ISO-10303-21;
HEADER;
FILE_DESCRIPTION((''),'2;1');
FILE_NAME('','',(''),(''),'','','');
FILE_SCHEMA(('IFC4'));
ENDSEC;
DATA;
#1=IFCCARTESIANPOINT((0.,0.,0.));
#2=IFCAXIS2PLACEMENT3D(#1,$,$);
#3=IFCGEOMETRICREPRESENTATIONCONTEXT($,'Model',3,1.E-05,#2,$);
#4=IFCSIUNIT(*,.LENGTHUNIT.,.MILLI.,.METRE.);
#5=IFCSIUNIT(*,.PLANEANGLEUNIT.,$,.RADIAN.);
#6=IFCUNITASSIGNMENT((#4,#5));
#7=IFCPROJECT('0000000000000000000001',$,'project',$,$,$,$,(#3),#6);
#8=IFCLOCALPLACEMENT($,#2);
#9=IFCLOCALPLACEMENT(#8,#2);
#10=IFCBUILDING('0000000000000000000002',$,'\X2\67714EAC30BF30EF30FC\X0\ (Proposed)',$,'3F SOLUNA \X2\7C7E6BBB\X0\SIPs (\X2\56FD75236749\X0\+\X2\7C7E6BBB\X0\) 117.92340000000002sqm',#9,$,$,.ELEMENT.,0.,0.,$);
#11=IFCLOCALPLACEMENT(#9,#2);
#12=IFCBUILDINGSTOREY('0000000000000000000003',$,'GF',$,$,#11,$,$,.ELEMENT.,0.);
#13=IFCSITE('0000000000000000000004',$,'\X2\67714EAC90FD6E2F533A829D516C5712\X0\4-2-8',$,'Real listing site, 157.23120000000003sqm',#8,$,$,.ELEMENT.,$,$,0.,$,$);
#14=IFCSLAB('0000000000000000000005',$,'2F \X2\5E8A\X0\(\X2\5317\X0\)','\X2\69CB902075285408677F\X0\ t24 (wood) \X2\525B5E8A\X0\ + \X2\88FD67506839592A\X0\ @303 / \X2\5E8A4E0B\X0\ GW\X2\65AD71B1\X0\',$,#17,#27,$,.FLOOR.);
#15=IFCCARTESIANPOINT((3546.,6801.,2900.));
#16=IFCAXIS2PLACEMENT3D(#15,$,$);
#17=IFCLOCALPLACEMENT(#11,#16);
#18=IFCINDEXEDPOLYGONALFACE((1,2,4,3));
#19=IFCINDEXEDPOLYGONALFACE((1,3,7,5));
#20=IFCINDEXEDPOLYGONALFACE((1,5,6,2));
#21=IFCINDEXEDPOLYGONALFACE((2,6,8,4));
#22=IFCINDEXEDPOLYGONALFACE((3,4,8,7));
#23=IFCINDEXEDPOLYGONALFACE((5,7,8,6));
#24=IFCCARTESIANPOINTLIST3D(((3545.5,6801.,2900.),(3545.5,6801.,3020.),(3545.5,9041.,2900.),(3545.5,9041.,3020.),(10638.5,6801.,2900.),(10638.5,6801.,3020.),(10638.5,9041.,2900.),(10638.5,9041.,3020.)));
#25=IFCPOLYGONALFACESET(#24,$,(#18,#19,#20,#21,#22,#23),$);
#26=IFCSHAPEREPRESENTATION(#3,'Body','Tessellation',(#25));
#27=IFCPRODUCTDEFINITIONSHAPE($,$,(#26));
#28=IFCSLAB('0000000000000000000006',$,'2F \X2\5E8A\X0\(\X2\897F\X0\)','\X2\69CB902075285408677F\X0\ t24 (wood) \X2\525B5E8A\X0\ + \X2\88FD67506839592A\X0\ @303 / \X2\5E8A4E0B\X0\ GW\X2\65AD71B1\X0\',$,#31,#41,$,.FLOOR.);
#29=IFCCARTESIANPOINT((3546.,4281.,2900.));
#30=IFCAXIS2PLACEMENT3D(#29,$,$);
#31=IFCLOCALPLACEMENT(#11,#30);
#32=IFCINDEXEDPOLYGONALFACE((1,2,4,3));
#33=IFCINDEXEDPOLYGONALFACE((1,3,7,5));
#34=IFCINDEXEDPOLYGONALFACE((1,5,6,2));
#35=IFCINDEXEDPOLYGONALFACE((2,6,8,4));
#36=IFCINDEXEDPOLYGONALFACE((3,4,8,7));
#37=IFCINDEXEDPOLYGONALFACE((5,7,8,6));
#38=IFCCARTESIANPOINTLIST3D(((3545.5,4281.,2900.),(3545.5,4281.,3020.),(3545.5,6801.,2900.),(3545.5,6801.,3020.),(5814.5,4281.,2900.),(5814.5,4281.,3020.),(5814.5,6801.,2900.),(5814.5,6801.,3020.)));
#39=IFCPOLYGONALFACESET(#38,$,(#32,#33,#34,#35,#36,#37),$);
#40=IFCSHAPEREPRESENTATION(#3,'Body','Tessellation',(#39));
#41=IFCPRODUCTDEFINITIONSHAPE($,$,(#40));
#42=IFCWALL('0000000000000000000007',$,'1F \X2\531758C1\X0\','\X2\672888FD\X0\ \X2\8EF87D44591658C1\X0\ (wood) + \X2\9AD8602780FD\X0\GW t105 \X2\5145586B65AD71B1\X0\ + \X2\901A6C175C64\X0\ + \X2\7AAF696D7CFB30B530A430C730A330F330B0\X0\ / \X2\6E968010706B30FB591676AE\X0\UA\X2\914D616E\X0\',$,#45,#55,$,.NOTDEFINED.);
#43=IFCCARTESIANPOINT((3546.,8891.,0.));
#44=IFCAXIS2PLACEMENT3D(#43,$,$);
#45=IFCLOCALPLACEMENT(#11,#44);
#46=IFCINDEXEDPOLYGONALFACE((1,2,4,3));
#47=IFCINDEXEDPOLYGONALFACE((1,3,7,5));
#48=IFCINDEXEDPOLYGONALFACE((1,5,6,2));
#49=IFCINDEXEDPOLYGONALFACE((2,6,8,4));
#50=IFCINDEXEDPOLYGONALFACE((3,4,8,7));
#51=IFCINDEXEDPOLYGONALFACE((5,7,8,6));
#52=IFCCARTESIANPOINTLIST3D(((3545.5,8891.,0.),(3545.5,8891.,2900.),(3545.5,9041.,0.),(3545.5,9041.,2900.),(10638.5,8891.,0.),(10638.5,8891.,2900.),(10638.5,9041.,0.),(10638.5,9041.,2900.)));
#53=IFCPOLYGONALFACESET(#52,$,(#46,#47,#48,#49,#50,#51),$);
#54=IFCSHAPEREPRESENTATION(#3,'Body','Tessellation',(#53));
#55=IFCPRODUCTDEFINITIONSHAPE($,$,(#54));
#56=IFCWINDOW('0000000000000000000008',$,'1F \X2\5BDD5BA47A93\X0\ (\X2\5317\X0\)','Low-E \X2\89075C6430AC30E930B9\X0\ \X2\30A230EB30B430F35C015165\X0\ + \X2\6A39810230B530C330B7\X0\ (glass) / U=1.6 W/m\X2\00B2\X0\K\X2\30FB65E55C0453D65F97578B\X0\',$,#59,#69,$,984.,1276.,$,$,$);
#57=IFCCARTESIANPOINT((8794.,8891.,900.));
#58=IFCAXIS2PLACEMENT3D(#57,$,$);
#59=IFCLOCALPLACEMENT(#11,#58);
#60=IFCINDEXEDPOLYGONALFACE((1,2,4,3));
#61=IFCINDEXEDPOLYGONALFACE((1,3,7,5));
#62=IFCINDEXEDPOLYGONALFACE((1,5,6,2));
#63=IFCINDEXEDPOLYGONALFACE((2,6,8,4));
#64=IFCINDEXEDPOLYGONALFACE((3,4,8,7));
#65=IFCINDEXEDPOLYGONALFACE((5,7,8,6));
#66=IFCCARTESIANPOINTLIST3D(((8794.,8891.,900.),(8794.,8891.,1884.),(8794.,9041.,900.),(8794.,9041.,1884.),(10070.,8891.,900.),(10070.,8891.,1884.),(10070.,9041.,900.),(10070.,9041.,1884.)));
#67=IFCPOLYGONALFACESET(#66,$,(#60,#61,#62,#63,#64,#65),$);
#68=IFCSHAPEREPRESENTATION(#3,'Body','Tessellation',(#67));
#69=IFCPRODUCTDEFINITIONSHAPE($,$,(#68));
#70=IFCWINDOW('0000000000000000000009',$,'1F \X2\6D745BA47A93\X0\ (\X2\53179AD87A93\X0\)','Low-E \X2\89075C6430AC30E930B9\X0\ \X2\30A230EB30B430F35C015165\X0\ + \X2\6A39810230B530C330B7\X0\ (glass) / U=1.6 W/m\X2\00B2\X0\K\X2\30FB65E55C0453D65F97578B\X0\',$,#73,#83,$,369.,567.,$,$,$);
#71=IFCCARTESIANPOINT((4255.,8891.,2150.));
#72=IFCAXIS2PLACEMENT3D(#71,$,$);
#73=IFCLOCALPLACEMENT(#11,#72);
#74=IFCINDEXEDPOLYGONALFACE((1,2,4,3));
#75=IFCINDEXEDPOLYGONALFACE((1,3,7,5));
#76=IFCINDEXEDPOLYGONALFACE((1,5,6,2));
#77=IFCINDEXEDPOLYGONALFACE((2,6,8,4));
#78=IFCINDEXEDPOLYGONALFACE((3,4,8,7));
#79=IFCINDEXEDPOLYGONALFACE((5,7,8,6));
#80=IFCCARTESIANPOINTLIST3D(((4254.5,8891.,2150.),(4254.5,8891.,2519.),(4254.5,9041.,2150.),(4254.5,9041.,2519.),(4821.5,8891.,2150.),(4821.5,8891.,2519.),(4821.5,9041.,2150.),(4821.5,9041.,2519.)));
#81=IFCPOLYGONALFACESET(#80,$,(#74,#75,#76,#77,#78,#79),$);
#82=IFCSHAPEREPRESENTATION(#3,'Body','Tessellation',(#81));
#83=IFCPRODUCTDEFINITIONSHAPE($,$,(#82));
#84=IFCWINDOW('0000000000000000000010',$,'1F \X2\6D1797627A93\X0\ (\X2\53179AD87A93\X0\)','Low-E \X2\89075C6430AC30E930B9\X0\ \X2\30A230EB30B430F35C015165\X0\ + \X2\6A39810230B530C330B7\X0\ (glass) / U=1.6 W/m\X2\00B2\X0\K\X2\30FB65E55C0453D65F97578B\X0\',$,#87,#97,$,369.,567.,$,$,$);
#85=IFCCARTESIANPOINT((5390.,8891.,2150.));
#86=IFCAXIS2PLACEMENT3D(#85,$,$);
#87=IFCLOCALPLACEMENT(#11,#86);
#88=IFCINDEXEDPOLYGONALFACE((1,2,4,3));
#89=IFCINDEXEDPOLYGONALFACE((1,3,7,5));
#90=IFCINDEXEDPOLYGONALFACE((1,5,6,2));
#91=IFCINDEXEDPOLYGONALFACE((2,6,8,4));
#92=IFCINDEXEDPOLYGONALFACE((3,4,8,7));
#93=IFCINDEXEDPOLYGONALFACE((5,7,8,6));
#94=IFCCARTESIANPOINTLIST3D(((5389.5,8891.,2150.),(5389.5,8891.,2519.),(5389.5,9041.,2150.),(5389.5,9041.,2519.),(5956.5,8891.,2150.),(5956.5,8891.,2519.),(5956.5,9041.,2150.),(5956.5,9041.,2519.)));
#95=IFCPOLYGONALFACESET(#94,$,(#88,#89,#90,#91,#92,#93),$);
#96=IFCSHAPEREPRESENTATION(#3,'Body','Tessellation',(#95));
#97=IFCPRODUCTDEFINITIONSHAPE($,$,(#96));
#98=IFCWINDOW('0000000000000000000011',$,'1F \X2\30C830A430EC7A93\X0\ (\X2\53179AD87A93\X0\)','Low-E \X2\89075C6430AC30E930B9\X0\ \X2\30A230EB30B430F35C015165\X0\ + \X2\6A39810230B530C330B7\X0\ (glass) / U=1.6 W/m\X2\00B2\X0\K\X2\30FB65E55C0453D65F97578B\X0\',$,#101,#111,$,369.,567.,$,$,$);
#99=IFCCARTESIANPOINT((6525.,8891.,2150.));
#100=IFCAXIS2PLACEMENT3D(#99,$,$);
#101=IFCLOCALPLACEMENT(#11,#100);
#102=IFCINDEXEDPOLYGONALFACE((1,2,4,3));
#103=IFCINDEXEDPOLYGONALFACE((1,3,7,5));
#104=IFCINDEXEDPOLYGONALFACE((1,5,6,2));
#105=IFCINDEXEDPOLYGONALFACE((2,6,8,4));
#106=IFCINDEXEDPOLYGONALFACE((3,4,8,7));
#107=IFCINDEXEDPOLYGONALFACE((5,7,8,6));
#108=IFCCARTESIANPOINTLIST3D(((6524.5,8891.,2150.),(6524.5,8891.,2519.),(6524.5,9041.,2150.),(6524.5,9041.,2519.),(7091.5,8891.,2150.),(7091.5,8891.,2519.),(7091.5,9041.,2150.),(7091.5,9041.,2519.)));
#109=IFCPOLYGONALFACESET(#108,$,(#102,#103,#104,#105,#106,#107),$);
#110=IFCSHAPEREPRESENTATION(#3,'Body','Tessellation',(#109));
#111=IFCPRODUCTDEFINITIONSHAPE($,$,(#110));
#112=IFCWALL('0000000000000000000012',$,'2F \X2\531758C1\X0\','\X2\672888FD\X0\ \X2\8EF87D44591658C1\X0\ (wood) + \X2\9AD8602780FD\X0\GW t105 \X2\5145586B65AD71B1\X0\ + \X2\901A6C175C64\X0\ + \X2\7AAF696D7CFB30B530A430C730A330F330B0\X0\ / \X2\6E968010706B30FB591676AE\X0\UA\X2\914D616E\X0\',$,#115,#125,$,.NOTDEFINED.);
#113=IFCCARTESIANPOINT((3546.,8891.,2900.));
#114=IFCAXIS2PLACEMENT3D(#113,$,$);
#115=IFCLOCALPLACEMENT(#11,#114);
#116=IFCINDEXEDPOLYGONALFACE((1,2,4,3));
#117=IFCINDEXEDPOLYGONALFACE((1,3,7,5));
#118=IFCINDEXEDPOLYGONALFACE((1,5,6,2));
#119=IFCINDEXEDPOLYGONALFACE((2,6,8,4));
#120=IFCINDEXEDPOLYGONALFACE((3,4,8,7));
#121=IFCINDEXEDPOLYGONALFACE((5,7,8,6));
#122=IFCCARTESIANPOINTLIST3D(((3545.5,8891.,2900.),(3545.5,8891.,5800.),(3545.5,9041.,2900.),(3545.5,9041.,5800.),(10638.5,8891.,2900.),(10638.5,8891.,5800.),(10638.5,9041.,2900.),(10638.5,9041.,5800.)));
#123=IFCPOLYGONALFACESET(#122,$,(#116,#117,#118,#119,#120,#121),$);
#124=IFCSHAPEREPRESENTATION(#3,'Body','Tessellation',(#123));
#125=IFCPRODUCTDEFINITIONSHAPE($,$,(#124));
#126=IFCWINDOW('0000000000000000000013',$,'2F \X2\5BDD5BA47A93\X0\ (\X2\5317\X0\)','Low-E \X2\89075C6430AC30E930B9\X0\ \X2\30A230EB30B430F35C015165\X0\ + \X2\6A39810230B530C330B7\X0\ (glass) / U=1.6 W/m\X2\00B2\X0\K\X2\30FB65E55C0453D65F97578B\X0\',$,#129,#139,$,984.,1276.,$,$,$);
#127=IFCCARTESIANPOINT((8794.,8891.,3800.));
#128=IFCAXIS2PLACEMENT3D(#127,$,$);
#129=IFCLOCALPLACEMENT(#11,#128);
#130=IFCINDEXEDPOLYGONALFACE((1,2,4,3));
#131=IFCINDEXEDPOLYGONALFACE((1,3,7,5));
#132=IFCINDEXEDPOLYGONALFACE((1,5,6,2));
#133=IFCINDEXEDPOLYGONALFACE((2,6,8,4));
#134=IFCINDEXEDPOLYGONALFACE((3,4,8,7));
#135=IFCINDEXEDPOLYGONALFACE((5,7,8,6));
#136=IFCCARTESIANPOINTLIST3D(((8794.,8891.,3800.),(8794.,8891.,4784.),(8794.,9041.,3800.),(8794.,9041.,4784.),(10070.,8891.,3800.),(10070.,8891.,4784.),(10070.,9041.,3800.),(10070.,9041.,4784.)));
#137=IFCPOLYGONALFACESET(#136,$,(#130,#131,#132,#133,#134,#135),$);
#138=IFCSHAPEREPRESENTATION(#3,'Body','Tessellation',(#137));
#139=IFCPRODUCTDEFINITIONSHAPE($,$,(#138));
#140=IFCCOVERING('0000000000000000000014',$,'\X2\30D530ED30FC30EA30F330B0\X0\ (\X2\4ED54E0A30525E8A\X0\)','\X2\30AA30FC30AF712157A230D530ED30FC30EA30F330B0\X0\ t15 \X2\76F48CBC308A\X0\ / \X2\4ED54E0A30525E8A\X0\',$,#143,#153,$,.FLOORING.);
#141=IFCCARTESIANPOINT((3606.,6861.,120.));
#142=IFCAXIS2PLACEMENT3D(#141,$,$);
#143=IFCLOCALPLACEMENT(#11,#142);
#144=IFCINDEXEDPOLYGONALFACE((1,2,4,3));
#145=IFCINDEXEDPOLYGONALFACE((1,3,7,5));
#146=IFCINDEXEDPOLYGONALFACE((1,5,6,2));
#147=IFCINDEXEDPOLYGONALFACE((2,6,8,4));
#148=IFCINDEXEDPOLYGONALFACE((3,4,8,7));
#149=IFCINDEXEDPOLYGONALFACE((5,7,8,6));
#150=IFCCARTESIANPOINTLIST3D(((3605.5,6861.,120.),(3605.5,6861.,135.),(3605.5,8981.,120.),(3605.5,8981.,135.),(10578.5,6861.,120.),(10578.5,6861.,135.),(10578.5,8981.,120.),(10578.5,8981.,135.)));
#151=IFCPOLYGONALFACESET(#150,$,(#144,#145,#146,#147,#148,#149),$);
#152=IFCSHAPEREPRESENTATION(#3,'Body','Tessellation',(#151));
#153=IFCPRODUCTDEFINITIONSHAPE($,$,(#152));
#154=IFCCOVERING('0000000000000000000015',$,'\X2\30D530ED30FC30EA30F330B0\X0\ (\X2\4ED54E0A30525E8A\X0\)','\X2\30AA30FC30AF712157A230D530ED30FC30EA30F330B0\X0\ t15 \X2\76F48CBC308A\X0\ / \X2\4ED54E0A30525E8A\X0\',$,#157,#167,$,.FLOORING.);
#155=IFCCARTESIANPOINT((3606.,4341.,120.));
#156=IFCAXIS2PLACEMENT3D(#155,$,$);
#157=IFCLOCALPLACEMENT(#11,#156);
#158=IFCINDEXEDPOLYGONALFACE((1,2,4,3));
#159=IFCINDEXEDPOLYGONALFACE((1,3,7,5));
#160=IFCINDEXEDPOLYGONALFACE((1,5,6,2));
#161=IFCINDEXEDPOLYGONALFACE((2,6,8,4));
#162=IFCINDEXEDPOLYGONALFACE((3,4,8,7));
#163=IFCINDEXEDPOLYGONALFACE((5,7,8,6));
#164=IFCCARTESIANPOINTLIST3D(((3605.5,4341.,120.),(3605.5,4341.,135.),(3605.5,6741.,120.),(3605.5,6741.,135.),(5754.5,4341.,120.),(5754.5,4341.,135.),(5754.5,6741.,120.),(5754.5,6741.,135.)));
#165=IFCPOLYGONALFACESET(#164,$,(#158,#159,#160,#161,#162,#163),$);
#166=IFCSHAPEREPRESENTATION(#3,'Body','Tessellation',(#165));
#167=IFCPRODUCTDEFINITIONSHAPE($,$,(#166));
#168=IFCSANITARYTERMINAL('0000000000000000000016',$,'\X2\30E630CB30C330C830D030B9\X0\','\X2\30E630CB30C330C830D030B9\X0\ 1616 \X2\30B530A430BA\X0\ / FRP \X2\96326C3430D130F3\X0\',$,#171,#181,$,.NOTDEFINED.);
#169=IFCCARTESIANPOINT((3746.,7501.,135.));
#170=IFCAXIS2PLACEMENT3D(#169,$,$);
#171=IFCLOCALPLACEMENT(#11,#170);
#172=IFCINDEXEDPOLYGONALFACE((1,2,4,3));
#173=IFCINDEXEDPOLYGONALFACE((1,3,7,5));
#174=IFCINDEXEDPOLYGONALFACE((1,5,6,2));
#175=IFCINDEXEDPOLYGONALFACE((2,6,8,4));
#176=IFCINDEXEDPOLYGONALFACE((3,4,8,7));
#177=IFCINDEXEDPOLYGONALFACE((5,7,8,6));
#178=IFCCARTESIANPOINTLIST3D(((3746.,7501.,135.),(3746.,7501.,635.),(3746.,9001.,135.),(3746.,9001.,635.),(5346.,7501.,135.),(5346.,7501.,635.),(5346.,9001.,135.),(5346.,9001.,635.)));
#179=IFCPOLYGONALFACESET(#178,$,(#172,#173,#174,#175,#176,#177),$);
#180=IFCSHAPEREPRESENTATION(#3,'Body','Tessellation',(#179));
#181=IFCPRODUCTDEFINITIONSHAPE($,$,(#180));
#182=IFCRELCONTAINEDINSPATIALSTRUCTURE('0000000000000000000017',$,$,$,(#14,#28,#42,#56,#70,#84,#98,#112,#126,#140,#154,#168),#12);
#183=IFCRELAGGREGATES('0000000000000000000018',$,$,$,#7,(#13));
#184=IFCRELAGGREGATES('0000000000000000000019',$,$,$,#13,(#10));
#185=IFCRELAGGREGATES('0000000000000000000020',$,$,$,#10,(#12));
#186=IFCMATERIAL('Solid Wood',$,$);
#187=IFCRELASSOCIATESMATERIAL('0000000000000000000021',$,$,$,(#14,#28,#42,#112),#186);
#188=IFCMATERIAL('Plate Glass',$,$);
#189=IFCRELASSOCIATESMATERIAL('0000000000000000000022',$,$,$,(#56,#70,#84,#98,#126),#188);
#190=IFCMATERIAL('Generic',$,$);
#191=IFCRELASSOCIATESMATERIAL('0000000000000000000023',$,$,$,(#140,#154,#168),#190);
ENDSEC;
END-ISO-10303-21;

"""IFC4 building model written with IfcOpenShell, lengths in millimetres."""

from ifc_helpers import new_model, si_unit, frame, frame_2d, origin, place, context, project, spatial, rectangle, extrude, material, element, fill, save


model = new_model("IFC4")

# Units and contexts
model_context = context("Model", 3, precision=1e-05, world=origin())
ifc_project = project(units=[si_unit("LENGTHUNIT", "METRE", prefix="MILLI"), si_unit("PLANEANGLEUNIT", "RADIAN")], contexts=[model_context])

# Site, building, storey
site_placement = place(None, origin())
site = spatial("IfcSite", under=ifc_project, at=site_placement, Name="東京都港区芝公園4-2-8", ObjectType="Real listing site, 157.23120000000003sqm", CompositionType="ELEMENT", RefElevation=0.0)
building_placement = place(site_placement, origin())
building = spatial("IfcBuilding", under=site, at=building_placement, Name="東京タワー (Proposed)", ObjectType="3F SOLUNA 籾殻SIPs (国産杉+籾殻) 117.92340000000002sqm", CompositionType="ELEMENT", ElevationOfRefHeight=0.0, ElevationOfTerrain=0.0)
storey_placement = place(building_placement, origin())
storey = spatial("IfcBuildingStorey", under=building, at=storey_placement, Name="GF", CompositionType="ELEMENT", Elevation=0.0)

# Slabs
ifc_material_1 = material(Name="Solid Wood")
slab_1_placement = place(storey_placement, frame((3546.0, 6801.0, 2900.0)))
element("IfcSlab", 1, at=slab_1_placement, inside=storey, material=ifc_material_1, Name="2F 床(北)", Description="構造用合板 t24 (wood) 剛床 + 製材根太 @303 / 床下 GW断熱", PredefinedType="FLOOR", context=model_context, shape_type="SweptSolid", body=[
    extrude(rectangle(XDim=7093.0, YDim=2240.0, at=frame_2d((3546.0, 1120.0))), frame((3546.0, 6801.0, 2900.0)), (0.0, 0.0, 1.0), 120.0),
])
slab_2_placement = place(storey_placement, frame((3546.0, 4281.0, 2900.0)))
element("IfcSlab", 2, at=slab_2_placement, inside=storey, material=ifc_material_1, Name="2F 床(西)", Description="構造用合板 t24 (wood) 剛床 + 製材根太 @303 / 床下 GW断熱", PredefinedType="FLOOR", context=model_context, shape_type="SweptSolid", body=[
    extrude(rectangle(XDim=2269.0, YDim=2520.0, at=frame_2d((1134.0, 1260.0))), frame((3546.0, 4281.0, 2900.0)), (0.0, 0.0, 1.0), 120.0),
])

# Wall, openings, windows
wall_1_placement = place(storey_placement, frame((3546.0, 8891.0, 0.0)))
wall_1 = element("IfcWall", 3, at=wall_1_placement, inside=storey, material=ifc_material_1, Name="1F 北壁", Description="木製 軸組外壁 (wood) + 高性能GW t105 充填断熱 + 通気層 + 窯業系サイディング / 準耐火・外皮UA配慮", PredefinedType="NOTDEFINED", context=model_context, shape_type="SweptSolid", body=[
    extrude(rectangle(XDim=7093.0, YDim=150.0, at=frame_2d((3546.0, 75.0))), frame((3546.0, 8891.0, 0.0)), (0.0, 0.0, 1.0), 2900.0),
])
opening_1_placement = place(storey_placement, frame((8794.0, 8891.0, 900.0)))
opening_1 = element("IfcOpeningElement", 4, at=opening_1_placement, cuts=wall_1, PredefinedType="NOTDEFINED", context=model_context, shape_type="SweptSolid", body=[
    extrude(rectangle(XDim=1276.0, YDim=150.0, at=frame_2d((638.0, 75.0))), frame((8794.0, 8891.0, 900.0)), (0.0, 0.0, 1.0), 984.0),
])
opening_2_placement = place(storey_placement, frame((4255.0, 8891.0, 2150.0)))
opening_2 = element("IfcOpeningElement", 5, at=opening_2_placement, cuts=wall_1, PredefinedType="NOTDEFINED", context=model_context, shape_type="SweptSolid", body=[
    extrude(rectangle(XDim=567.0, YDim=150.0, at=frame_2d((283.0, 75.0))), frame((4255.0, 8891.0, 2150.0)), (0.0, 0.0, 1.0), 369.0),
])
opening_3_placement = place(storey_placement, frame((5390.0, 8891.0, 2150.0)))
opening_3 = element("IfcOpeningElement", 6, at=opening_3_placement, cuts=wall_1, PredefinedType="NOTDEFINED", context=model_context, shape_type="SweptSolid", body=[
    extrude(rectangle(XDim=567.0, YDim=150.0, at=frame_2d((283.0, 75.0))), frame((5390.0, 8891.0, 2150.0)), (0.0, 0.0, 1.0), 369.0),
])
opening_4_placement = place(storey_placement, frame((6525.0, 8891.0, 2150.0)))
opening_4 = element("IfcOpeningElement", 7, at=opening_4_placement, cuts=wall_1, PredefinedType="NOTDEFINED", context=model_context, shape_type="SweptSolid", body=[
    extrude(rectangle(XDim=567.0, YDim=150.0, at=frame_2d((283.0, 75.0))), frame((6525.0, 8891.0, 2150.0)), (0.0, 0.0, 1.0), 369.0),
])
ifc_material_2 = material(Name="Plate Glass")
window_1_placement = place(storey_placement, frame((8794.0, 8891.0, 900.0)))
window_1 = element("IfcWindow", 8, at=window_1_placement, inside=storey, material=ifc_material_2, Name="1F 寝室窓 (北)", Description="Low-E 複層ガラス アルゴン封入 + 樹脂サッシ (glass) / U=1.6 W/m²K・日射取得型", OverallHeight=984.0, OverallWidth=1276.0, context=model_context, shape_type="SweptSolid", body=[
    extrude(rectangle(XDim=1276.0, YDim=150.0, at=frame_2d((638.0, 75.0))), frame((8794.0, 8891.0, 900.0)), (0.0, 0.0, 1.0), 984.0),
])
fill(opening_1, window_1)
window_2_placement = place(storey_placement, frame((4255.0, 8891.0, 2150.0)))
window_2 = element("IfcWindow", 9, at=window_2_placement, inside=storey, material=ifc_material_2, Name="1F 浴室窓 (北高窓)", Description="Low-E 複層ガラス アルゴン封入 + 樹脂サッシ (glass) / U=1.6 W/m²K・日射取得型", OverallHeight=369.0, OverallWidth=567.0, context=model_context, shape_type="SweptSolid", body=[
    extrude(rectangle(XDim=567.0, YDim=150.0, at=frame_2d((283.0, 75.0))), frame((4255.0, 8891.0, 2150.0)), (0.0, 0.0, 1.0), 369.0),
])
fill(opening_2, window_2)
window_3_placement = place(storey_placement, frame((5390.0, 8891.0, 2150.0)))
window_3 = element("IfcWindow", 10, at=window_3_placement, inside=storey, material=ifc_material_2, Name="1F 洗面窓 (北高窓)", Description="Low-E 複層ガラス アルゴン封入 + 樹脂サッシ (glass) / U=1.6 W/m²K・日射取得型", OverallHeight=369.0, OverallWidth=567.0, context=model_context, shape_type="SweptSolid", body=[
    extrude(rectangle(XDim=567.0, YDim=150.0, at=frame_2d((283.0, 75.0))), frame((5390.0, 8891.0, 2150.0)), (0.0, 0.0, 1.0), 369.0),
])
fill(opening_3, window_3)
window_4_placement = place(storey_placement, frame((6525.0, 8891.0, 2150.0)))
window_4 = element("IfcWindow", 11, at=window_4_placement, inside=storey, material=ifc_material_2, Name="1F トイレ窓 (北高窓)", Description="Low-E 複層ガラス アルゴン封入 + 樹脂サッシ (glass) / U=1.6 W/m²K・日射取得型", OverallHeight=369.0, OverallWidth=567.0, context=model_context, shape_type="SweptSolid", body=[
    extrude(rectangle(XDim=567.0, YDim=150.0, at=frame_2d((283.0, 75.0))), frame((6525.0, 8891.0, 2150.0)), (0.0, 0.0, 1.0), 369.0),
])
fill(opening_4, window_4)

# Wall, opening, window
wall_2_placement = place(storey_placement, frame((3546.0, 8891.0, 2900.0)))
wall_2 = element("IfcWall", 12, at=wall_2_placement, inside=storey, material=ifc_material_1, Name="2F 北壁", Description="木製 軸組外壁 (wood) + 高性能GW t105 充填断熱 + 通気層 + 窯業系サイディング / 準耐火・外皮UA配慮", PredefinedType="NOTDEFINED", context=model_context, shape_type="SweptSolid", body=[
    extrude(rectangle(XDim=7093.0, YDim=150.0, at=frame_2d((3546.0, 75.0))), frame((3546.0, 8891.0, 2900.0)), (0.0, 0.0, 1.0), 2900.0),
])
opening_5_placement = place(storey_placement, frame((8794.0, 8891.0, 3800.0)))
opening_5 = element("IfcOpeningElement", 13, at=opening_5_placement, cuts=wall_2, PredefinedType="NOTDEFINED", context=model_context, shape_type="SweptSolid", body=[
    extrude(rectangle(XDim=1276.0, YDim=150.0, at=frame_2d((638.0, 75.0))), frame((8794.0, 8891.0, 3800.0)), (0.0, 0.0, 1.0), 984.0),
])
window_5_placement = place(storey_placement, frame((8794.0, 8891.0, 3800.0)))
window_5 = element("IfcWindow", 14, at=window_5_placement, inside=storey, material=ifc_material_2, Name="2F 寝室窓 (北)", Description="Low-E 複層ガラス アルゴン封入 + 樹脂サッシ (glass) / U=1.6 W/m²K・日射取得型", OverallHeight=984.0, OverallWidth=1276.0, context=model_context, shape_type="SweptSolid", body=[
    extrude(rectangle(XDim=1276.0, YDim=150.0, at=frame_2d((638.0, 75.0))), frame((8794.0, 8891.0, 3800.0)), (0.0, 0.0, 1.0), 984.0),
])
fill(opening_5, window_5)

# Coverings
ifc_material_3 = material(Name="Generic")
covering_1_placement = place(storey_placement, frame((3606.0, 6861.0, 120.0)))
element("IfcCovering", 15, at=covering_1_placement, inside=storey, material=ifc_material_3, Name="フローリング (仕上げ床)", Description="オーク無垢フローリング t15 直貼り / 仕上げ床", PredefinedType="FLOORING", context=model_context, shape_type="SweptSolid", body=[
    extrude(rectangle(XDim=6973.0, YDim=2120.0, at=frame_2d((3486.0, 1060.0))), frame((3606.0, 6861.0, 120.0)), (0.0, 0.0, 1.0), 15.0),
])
covering_2_placement = place(storey_placement, frame((3606.0, 4341.0, 120.0)))
element("IfcCovering", 16, at=covering_2_placement, inside=storey, material=ifc_material_3, Name="フローリング (仕上げ床)", Description="オーク無垢フローリング t15 直貼り / 仕上げ床", PredefinedType="FLOORING", context=model_context, shape_type="SweptSolid", body=[
    extrude(rectangle(XDim=2149.0, YDim=2400.0, at=frame_2d((1074.0, 1200.0))), frame((3606.0, 4341.0, 120.0)), (0.0, 0.0, 1.0), 15.0),
])

# Sanitary terminal
sanitary_terminal_1_placement = place(storey_placement, frame((3746.0, 7501.0, 135.0)))
element("IfcSanitaryTerminal", 17, at=sanitary_terminal_1_placement, inside=storey, material=ifc_material_3, Name="ユニットバス", Description="ユニットバス 1616 サイズ / FRP 防水パン", PredefinedType="NOTDEFINED", context=model_context, shape_type="SweptSolid", body=[
    extrude(rectangle(XDim=1600.0, YDim=1500.0, at=frame_2d((800.0, 750.0))), frame((3746.0, 7501.0, 135.0)), (0.0, 0.0, 1.0), 500.0),
])

save(model, "model.ifc")
